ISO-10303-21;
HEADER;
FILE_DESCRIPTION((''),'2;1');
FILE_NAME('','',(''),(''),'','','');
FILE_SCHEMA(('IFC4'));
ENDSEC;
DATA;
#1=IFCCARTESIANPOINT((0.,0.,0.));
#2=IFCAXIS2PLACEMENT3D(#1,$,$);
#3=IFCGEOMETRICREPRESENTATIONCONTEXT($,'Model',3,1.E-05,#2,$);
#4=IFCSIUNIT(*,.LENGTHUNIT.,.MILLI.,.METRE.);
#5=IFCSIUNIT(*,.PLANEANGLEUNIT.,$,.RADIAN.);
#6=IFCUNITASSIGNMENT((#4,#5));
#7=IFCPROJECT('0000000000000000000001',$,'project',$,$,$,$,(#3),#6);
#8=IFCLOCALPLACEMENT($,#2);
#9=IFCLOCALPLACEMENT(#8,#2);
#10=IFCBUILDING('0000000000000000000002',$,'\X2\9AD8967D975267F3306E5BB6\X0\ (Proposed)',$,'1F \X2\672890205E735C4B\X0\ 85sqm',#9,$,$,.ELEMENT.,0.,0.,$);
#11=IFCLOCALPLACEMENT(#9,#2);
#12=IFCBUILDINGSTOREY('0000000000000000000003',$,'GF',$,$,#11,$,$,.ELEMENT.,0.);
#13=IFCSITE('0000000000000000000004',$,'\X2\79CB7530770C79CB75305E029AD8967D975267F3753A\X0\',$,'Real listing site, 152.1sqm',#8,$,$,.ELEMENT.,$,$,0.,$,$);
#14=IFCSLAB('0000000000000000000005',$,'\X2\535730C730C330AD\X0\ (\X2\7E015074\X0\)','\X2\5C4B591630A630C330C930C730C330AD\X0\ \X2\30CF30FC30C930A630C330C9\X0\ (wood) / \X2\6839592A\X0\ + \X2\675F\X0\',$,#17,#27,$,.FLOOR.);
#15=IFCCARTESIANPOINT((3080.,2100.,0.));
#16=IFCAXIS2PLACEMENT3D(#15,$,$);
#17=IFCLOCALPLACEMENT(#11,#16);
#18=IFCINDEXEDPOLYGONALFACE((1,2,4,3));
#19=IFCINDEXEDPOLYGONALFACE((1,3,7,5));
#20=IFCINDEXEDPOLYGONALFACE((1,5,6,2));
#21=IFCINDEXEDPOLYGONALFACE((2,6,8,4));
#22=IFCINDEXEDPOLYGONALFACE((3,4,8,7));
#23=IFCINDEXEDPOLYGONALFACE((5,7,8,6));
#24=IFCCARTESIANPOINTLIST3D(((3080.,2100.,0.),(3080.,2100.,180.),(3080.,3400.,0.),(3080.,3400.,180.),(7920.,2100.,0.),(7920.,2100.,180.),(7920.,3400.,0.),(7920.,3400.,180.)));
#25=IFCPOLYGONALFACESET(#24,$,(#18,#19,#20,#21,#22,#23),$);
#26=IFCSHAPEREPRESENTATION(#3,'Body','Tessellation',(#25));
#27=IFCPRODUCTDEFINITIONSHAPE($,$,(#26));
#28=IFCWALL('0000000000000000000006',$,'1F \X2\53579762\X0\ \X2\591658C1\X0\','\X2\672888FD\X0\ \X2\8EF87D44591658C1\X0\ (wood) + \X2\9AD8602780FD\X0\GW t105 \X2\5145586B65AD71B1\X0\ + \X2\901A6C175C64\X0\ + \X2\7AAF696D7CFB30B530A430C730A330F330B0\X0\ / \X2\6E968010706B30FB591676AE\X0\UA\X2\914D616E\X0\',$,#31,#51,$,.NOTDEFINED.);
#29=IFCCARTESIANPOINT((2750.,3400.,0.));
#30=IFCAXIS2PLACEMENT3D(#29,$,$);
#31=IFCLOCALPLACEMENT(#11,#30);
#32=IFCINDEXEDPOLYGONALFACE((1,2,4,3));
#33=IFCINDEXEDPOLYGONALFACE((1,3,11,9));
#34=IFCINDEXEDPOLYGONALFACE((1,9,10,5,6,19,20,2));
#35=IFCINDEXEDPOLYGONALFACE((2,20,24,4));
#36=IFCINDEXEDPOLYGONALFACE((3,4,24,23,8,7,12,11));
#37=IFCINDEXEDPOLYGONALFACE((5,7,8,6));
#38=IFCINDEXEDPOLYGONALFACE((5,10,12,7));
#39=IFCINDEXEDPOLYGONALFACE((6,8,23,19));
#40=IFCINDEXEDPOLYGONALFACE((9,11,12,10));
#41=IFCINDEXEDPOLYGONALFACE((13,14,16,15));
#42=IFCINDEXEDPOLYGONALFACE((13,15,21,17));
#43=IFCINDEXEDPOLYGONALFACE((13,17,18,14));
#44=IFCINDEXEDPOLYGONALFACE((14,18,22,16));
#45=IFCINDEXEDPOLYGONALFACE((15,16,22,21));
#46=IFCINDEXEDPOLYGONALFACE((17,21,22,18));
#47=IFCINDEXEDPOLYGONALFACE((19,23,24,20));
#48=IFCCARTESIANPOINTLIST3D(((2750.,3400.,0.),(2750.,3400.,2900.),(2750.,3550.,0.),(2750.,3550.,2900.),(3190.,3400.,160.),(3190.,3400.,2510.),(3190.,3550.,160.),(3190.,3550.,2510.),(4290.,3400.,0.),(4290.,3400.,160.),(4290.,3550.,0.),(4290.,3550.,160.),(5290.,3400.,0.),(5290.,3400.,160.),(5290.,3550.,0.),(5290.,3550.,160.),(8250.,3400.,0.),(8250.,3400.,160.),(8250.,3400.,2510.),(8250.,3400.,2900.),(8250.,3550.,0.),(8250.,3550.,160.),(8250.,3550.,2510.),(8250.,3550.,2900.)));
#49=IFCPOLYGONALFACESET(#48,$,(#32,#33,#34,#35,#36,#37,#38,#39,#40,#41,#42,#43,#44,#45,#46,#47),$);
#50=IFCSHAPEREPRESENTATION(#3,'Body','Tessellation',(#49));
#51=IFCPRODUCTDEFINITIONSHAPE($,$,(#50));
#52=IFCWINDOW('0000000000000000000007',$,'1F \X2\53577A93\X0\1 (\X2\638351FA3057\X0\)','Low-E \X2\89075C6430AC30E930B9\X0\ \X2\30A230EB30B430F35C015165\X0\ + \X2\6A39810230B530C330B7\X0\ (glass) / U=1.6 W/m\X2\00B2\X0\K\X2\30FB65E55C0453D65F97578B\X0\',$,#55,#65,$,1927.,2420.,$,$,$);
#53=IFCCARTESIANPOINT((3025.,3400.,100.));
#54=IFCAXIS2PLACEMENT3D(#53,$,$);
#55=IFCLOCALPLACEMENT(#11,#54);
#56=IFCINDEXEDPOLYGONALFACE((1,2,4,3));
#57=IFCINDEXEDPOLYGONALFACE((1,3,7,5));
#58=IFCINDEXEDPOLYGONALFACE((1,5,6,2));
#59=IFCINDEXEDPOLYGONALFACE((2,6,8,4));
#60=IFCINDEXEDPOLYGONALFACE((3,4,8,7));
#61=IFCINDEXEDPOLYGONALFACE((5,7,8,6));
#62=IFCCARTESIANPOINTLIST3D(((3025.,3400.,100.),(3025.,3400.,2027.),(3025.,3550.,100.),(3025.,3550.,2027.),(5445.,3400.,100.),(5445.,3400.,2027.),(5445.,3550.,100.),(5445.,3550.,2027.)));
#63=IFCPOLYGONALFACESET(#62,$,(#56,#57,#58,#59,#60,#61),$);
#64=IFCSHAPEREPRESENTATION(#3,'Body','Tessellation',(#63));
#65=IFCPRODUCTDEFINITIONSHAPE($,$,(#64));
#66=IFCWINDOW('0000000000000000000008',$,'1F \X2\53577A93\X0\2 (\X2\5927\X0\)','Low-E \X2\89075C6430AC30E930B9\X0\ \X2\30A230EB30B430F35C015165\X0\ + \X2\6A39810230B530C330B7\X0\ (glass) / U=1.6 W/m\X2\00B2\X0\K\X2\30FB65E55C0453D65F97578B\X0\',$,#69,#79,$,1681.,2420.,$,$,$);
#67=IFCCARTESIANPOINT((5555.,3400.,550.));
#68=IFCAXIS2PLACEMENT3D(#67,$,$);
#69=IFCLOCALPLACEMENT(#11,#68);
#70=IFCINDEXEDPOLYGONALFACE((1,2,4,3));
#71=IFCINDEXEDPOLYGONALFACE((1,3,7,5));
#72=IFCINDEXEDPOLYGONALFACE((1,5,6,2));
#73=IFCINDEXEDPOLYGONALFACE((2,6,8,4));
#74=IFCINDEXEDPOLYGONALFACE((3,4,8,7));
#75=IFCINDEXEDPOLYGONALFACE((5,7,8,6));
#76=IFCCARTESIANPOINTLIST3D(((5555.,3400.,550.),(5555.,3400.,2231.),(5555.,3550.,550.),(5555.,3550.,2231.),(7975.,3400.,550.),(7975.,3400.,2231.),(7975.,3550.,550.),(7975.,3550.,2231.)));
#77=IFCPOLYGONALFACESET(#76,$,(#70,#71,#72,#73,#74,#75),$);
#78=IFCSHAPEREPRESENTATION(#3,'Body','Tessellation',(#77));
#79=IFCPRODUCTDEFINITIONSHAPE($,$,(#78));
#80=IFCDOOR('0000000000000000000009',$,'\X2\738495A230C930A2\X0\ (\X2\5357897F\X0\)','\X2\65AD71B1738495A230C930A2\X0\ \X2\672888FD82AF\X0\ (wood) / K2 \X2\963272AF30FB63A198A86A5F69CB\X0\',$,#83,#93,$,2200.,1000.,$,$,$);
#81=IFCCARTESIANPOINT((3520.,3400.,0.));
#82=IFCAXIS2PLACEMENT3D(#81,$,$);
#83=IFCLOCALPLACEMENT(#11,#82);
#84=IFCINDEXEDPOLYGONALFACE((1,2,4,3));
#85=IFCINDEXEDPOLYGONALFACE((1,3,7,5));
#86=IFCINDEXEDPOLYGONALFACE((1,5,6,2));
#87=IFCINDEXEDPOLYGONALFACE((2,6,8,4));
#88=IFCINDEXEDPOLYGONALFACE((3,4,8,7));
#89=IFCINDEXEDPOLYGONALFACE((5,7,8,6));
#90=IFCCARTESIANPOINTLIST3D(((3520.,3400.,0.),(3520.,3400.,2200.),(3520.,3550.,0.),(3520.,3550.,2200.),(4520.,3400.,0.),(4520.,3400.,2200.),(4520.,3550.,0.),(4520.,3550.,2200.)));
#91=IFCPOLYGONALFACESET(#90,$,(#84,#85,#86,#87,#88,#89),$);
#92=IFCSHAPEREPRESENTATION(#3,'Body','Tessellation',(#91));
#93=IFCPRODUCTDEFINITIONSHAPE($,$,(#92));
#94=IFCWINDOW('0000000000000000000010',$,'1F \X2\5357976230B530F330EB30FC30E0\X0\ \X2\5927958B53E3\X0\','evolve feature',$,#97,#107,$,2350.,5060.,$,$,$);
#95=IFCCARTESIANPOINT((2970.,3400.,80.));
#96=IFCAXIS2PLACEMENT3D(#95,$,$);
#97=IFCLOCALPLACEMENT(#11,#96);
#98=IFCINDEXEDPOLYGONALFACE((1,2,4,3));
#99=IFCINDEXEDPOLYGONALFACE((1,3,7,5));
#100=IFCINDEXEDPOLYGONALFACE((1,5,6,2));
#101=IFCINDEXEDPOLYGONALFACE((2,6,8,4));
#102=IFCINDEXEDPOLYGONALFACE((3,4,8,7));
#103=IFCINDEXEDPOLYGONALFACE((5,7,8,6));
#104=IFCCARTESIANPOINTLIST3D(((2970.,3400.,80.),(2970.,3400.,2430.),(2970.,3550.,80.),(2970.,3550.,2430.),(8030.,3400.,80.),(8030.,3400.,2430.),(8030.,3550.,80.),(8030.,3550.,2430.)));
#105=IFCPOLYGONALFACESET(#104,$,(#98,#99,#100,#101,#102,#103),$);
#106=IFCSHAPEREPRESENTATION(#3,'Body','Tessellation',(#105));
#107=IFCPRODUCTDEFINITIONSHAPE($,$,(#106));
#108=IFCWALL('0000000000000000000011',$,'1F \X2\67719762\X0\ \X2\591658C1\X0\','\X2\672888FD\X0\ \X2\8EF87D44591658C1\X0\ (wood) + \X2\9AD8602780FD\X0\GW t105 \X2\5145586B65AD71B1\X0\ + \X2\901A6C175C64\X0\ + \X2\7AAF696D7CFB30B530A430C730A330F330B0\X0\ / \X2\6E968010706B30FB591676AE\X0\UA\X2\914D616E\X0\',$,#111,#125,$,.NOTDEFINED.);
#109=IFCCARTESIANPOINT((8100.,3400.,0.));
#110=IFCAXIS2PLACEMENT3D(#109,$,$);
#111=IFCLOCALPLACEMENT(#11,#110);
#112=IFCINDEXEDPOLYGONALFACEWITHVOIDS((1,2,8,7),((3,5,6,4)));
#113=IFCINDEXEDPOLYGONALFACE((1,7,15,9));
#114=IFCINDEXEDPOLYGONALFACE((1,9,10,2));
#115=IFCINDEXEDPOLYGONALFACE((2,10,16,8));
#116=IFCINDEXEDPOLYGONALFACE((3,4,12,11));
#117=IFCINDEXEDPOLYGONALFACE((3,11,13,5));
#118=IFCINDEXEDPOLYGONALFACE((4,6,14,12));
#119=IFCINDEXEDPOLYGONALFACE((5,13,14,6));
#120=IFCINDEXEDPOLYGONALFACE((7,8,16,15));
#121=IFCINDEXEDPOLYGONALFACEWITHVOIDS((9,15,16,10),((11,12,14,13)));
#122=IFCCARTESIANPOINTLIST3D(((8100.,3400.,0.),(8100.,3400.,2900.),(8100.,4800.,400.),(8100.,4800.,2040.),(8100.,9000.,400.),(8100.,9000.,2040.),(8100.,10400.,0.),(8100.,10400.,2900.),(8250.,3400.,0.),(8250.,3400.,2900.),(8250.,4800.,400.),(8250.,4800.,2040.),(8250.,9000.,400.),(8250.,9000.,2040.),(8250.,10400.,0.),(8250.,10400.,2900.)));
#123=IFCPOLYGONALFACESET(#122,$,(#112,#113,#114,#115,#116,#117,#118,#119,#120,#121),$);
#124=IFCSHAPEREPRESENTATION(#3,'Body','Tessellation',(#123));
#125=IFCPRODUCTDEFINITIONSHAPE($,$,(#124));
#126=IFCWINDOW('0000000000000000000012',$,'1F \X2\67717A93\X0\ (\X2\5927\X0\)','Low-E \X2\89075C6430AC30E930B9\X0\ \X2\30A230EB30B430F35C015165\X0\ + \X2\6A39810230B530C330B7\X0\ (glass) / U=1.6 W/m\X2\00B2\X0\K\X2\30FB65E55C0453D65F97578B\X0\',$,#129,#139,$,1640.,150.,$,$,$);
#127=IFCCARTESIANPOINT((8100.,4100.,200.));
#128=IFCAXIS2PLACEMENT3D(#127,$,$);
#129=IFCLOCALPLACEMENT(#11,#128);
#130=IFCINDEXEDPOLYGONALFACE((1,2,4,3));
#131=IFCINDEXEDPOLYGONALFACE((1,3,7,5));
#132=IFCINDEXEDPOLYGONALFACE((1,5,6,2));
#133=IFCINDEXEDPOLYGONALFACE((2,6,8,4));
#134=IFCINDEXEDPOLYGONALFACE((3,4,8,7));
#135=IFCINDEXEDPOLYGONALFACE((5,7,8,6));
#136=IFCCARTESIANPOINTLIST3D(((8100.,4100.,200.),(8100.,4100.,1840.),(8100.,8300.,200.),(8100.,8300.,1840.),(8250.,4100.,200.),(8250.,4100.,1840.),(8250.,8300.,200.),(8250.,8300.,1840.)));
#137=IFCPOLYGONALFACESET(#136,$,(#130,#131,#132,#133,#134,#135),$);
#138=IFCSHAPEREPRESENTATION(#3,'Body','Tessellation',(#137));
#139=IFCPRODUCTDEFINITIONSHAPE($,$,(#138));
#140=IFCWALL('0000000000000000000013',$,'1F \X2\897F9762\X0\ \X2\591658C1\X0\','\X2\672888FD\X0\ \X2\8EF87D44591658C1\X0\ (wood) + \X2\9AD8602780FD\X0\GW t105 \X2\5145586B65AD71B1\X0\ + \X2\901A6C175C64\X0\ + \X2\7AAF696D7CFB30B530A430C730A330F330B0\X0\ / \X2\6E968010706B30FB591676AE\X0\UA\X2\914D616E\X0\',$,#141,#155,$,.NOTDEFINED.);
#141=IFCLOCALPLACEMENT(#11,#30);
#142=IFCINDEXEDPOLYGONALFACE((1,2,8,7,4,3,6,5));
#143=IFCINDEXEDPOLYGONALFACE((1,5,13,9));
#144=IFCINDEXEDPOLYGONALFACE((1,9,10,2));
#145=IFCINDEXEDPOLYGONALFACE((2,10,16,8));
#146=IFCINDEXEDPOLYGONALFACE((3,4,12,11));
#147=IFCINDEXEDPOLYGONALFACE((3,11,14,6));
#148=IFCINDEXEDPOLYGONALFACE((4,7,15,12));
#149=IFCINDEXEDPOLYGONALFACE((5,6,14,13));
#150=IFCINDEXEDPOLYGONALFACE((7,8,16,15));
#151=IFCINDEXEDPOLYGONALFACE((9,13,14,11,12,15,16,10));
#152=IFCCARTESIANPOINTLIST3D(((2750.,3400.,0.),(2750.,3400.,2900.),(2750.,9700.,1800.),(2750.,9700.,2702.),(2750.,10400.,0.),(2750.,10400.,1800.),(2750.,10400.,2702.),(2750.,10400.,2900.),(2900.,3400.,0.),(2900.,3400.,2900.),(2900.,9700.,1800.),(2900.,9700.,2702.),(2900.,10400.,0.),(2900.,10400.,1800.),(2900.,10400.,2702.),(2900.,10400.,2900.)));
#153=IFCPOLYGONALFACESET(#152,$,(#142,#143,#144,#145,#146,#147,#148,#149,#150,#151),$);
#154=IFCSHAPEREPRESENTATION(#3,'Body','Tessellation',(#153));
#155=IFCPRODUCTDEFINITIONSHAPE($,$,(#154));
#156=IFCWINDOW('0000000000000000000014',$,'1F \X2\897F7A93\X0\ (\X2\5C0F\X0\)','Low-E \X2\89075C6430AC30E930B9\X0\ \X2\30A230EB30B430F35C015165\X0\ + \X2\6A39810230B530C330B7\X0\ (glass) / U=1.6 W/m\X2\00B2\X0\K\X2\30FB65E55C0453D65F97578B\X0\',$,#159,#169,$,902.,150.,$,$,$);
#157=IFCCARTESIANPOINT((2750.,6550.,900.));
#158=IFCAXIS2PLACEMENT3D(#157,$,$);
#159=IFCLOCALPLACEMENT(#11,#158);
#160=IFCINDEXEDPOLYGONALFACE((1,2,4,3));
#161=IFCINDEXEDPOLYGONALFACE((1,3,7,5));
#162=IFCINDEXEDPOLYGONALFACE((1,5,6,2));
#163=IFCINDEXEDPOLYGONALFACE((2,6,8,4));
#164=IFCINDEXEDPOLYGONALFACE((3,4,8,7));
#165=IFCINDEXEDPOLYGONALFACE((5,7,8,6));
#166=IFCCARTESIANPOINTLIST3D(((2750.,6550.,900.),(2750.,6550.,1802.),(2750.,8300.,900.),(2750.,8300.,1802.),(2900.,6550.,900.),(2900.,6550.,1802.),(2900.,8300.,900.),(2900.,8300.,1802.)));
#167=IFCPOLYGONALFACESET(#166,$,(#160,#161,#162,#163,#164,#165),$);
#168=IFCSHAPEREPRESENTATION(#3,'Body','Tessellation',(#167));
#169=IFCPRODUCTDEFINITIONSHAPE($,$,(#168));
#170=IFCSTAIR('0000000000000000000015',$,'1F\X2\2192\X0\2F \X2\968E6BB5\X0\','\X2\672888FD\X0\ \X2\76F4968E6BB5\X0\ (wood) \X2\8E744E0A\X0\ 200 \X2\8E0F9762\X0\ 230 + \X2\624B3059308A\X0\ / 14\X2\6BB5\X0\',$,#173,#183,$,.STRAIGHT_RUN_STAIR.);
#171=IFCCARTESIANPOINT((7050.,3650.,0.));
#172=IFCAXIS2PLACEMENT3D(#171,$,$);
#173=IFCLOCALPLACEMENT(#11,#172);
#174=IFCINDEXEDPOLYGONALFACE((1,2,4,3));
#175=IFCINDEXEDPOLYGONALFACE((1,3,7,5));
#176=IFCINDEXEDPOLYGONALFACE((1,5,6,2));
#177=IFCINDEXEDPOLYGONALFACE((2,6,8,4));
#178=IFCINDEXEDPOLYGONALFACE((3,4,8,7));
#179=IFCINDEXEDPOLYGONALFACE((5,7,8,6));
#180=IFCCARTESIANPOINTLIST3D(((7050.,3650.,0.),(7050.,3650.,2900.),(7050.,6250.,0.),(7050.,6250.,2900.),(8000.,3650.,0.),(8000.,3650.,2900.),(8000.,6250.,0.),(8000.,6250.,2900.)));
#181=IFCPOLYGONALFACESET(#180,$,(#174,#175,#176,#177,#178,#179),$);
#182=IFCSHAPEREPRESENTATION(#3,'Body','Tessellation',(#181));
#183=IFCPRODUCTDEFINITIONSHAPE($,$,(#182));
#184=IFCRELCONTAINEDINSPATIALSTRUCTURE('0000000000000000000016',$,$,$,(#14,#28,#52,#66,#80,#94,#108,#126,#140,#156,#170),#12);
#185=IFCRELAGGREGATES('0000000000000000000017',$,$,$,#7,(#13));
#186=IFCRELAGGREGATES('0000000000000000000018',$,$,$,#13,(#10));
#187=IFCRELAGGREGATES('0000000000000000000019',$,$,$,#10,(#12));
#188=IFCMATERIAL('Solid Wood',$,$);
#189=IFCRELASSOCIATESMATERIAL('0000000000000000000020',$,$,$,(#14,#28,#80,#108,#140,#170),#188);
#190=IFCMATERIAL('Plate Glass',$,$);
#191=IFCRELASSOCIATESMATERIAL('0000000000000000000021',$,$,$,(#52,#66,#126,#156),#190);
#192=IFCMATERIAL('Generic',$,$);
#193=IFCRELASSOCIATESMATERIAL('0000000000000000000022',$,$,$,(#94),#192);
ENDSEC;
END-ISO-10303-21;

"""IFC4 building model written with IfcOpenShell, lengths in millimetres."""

from ifc_helpers import new_model, si_unit, frame, frame_2d, origin, place, context, project, spatial, rectangle, extrude, material, element, fill, save


model = new_model("IFC4")

# Units and contexts
model_context = context("Model", 3, precision=1e-05, world=origin())
ifc_project = project(units=[si_unit("LENGTHUNIT", "METRE", prefix="MILLI"), si_unit("PLANEANGLEUNIT", "RADIAN")], contexts=[model_context])

# Site, building, storey
site_placement = place(None, origin())
site = spatial("IfcSite", under=ifc_project, at=site_placement, Name="秋田県秋田市高陽青柳町", ObjectType="Real listing site, 152.1sqm", CompositionType="ELEMENT", RefElevation=0.0)
building_placement = place(site_placement, origin())
building = spatial("IfcBuilding", under=site, at=building_placement, Name="高陽青柳の家 (Proposed)", ObjectType="1F 木造平屋 85sqm", CompositionType="ELEMENT", ElevationOfRefHeight=0.0, ElevationOfTerrain=0.0)
storey_placement = place(building_placement, origin())
storey = spatial("IfcBuildingStorey", under=building, at=storey_placement, Name="GF", CompositionType="ELEMENT", Elevation=0.0)

# Slab
ifc_material_1 = material(Name="Solid Wood")
slab_1_placement = place(storey_placement, frame((3080.0, 2100.0, 0.0)))
element("IfcSlab", 1, at=slab_1_placement, inside=storey, material=ifc_material_1, Name="南デッキ (縁側)", Description="屋外ウッドデッキ ハードウッド (wood) / 根太 + 束", PredefinedType="FLOOR", context=model_context, shape_type="SweptSolid", body=[
    extrude(rectangle(XDim=4840.0, YDim=1300.0, at=frame_2d((2420.0, 650.0))), frame((3080.0, 2100.0, 0.0)), (0.0, 0.0, 1.0), 180.0),
])
ifc_material_2 = material(Name="Generic")

# Wall, openings, windows, door
wall_1_placement = place(storey_placement, frame((2750.0, 3400.0, 0.0)))
wall_1 = element("IfcWall", 2, at=wall_1_placement, inside=storey, material=ifc_material_1, Name="1F 南面 外壁", Description="木製 軸組外壁 (wood) + 高性能GW t105 充填断熱 + 通気層 + 窯業系サイディング / 準耐火・外皮UA配慮", PredefinedType="NOTDEFINED", context=model_context, shape_type="SweptSolid", body=[
    extrude(rectangle(XDim=5500.0, YDim=150.0, at=frame_2d((2750.0, 75.0))), frame((2750.0, 3400.0, 0.0)), (0.0, 0.0, 1.0), 2900.0),
])
opening_1_placement = place(storey_placement, frame((3025.0, 3400.0, 100.0)))
opening_1 = element("IfcOpeningElement", 3, at=opening_1_placement, cuts=wall_1, PredefinedType="NOTDEFINED", context=model_context, shape_type="SweptSolid", body=[
    extrude(rectangle(XDim=2420.0, YDim=150.0, at=frame_2d((1210.0, 75.0))), frame((3025.0, 3400.0, 100.0)), (0.0, 0.0, 1.0), 1927.0),
])
opening_2_placement = place(storey_placement, frame((5555.0, 3400.0, 550.0)))
opening_2 = element("IfcOpeningElement", 4, at=opening_2_placement, cuts=wall_1, PredefinedType="NOTDEFINED", context=model_context, shape_type="SweptSolid", body=[
    extrude(rectangle(XDim=2420.0, YDim=150.0, at=frame_2d((1210.0, 75.0))), frame((5555.0, 3400.0, 550.0)), (0.0, 0.0, 1.0), 1681.0),
])
opening_3_placement = place(storey_placement, frame((3520.0, 3400.0, 0.0)))
opening_3 = element("IfcOpeningElement", 5, at=opening_3_placement, cuts=wall_1, PredefinedType="NOTDEFINED", context=model_context, shape_type="SweptSolid", body=[
    extrude(rectangle(XDim=1000.0, YDim=150.0, at=frame_2d((500.0, 75.0))), frame((3520.0, 3400.0, 0.0)), (0.0, 0.0, 1.0), 2200.0),
])
opening_4_placement = place(storey_placement, frame((2970.0, 3400.0, 80.0)))
opening_4 = element("IfcOpeningElement", 6, at=opening_4_placement, cuts=wall_1, PredefinedType="NOTDEFINED", context=model_context, shape_type="SweptSolid", body=[
    extrude(rectangle(XDim=5060.0, YDim=150.0, at=frame_2d((2530.0, 75.0))), frame((2970.0, 3400.0, 80.0)), (0.0, 0.0, 1.0), 2350.0),
])
ifc_material_3 = material(Name="Plate Glass")
window_1_placement = place(storey_placement, frame((3025.0, 3400.0, 100.0)))
window_1 = element("IfcWindow", 7, at=window_1_placement, inside=storey, material=ifc_material_3, Name="1F 南窓1 (掃出し)", Description="Low-E 複層ガラス アルゴン封入 + 樹脂サッシ (glass) / U=1.6 W/m²K・日射取得型", OverallHeight=1927.0, OverallWidth=2420.0, context=model_context, shape_type="SweptSolid", body=[
    extrude(rectangle(XDim=2420.0, YDim=150.0, at=frame_2d((1210.0, 75.0))), frame((3025.0, 3400.0, 100.0)), (0.0, 0.0, 1.0), 1927.0),
])
fill(opening_1, window_1)
window_2_placement = place(storey_placement, frame((5555.0, 3400.0, 550.0)))
window_2 = element("IfcWindow", 8, at=window_2_placement, inside=storey, material=ifc_material_3, Name="1F 南窓2 (大)", Description="Low-E 複層ガラス アルゴン封入 + 樹脂サッシ (glass) / U=1.6 W/m²K・日射取得型", OverallHeight=1681.0, OverallWidth=2420.0, context=model_context, shape_type="SweptSolid", body=[
    extrude(rectangle(XDim=2420.0, YDim=150.0, at=frame_2d((1210.0, 75.0))), frame((5555.0, 3400.0, 550.0)), (0.0, 0.0, 1.0), 1681.0),
])
fill(opening_2, window_2)
door_placement = place(storey_placement, frame((3520.0, 3400.0, 0.0)))
door = element("IfcDoor", 9, at=door_placement, inside=storey, material=ifc_material_1, Name="玄関ドア (南西)", Description="断熱玄関ドア 木製芯 (wood) / K2 防犯・採風機構", OverallHeight=2200.0, OverallWidth=1000.0, context=model_context, shape_type="SweptSolid", body=[
    extrude(rectangle(XDim=1000.0, YDim=150.0, at=frame_2d((500.0, 75.0))), frame((3520.0, 3400.0, 0.0)), (0.0, 0.0, 1.0), 2200.0),
])
fill(opening_3, door)
window_3_placement = place(storey_placement, frame((2970.0, 3400.0, 80.0)))
window_3 = element("IfcWindow", 10, at=window_3_placement, inside=storey, material=ifc_material_2, Name="1F 南面サンルーム 大開口", Description="evolve feature", OverallHeight=2350.0, OverallWidth=5060.0, context=model_context, shape_type="SweptSolid", body=[
    extrude(rectangle(XDim=5060.0, YDim=150.0, at=frame_2d((2530.0, 75.0))), frame((2970.0, 3400.0, 80.0)), (0.0, 0.0, 1.0), 2350.0),
])
fill(opening_4, window_3)

# Walls, openings, windows
wall_2_placement = place(storey_placement, frame((8100.0, 3400.0, 0.0)))
wall_2 = element("IfcWall", 11, at=wall_2_placement, inside=storey, material=ifc_material_1, Name="1F 東面 外壁", Description="木製 軸組外壁 (wood) + 高性能GW t105 充填断熱 + 通気層 + 窯業系サイディング / 準耐火・外皮UA配慮", PredefinedType="NOTDEFINED", context=model_context, shape_type="SweptSolid", body=[
    extrude(rectangle(XDim=150.0, YDim=7000.0, at=frame_2d((75.0, 3500.0))), frame((8100.0, 3400.0, 0.0)), (0.0, 0.0, 1.0), 2900.0),
])
opening_5_placement = place(storey_placement, frame((8100.0, 4100.0, 200.0)))
opening_5 = element("IfcOpeningElement", 12, at=opening_5_placement, cuts=wall_2, PredefinedType="NOTDEFINED", context=model_context, shape_type="SweptSolid", body=[
    extrude(rectangle(XDim=150.0, YDim=4200.0, at=frame_2d((75.0, 2100.0))), frame((8100.0, 4100.0, 200.0)), (0.0, 0.0, 1.0), 1640.0),
])
window_4_placement = place(storey_placement, frame((8100.0, 4100.0, 200.0)))
window_4 = element("IfcWindow", 13, at=window_4_placement, inside=storey, material=ifc_material_3, Name="1F 東窓 (大)", Description="Low-E 複層ガラス アルゴン封入 + 樹脂サッシ (glass) / U=1.6 W/m²K・日射取得型", OverallHeight=1640.0, OverallWidth=150.0, context=model_context, shape_type="SweptSolid", body=[
    extrude(rectangle(XDim=150.0, YDim=4200.0, at=frame_2d((75.0, 2100.0))), frame((8100.0, 4100.0, 200.0)), (0.0, 0.0, 1.0), 1640.0),
])
fill(opening_5, window_4)
wall_3_placement = place(storey_placement, frame((2750.0, 3400.0, 0.0)))
wall_3 = element("IfcWall", 14, at=wall_3_placement, inside=storey, material=ifc_material_1, Name="1F 西面 外壁", Description="木製 軸組外壁 (wood) + 高性能GW t105 充填断熱 + 通気層 + 窯業系サイディング / 準耐火・外皮UA配慮", PredefinedType="NOTDEFINED", context=model_context, shape_type="SweptSolid", body=[
    extrude(rectangle(XDim=150.0, YDim=7000.0, at=frame_2d((75.0, 3500.0))), frame((2750.0, 3400.0, 0.0)), (0.0, 0.0, 1.0), 2900.0),
])
opening_6_placement = place(storey_placement, frame((2750.0, 6550.0, 900.0)))
opening_6 = element("IfcOpeningElement", 15, at=opening_6_placement, cuts=wall_3, PredefinedType="NOTDEFINED", context=model_context, shape_type="SweptSolid", body=[
    extrude(rectangle(XDim=150.0, YDim=1750.0, at=frame_2d((75.0, 875.0))), frame((2750.0, 6550.0, 900.0)), (0.0, 0.0, 1.0), 902.0),
])
window_5_placement = place(storey_placement, frame((2750.0, 6550.0, 900.0)))
window_5 = element("IfcWindow", 16, at=window_5_placement, inside=storey, material=ifc_material_3, Name="1F 西窓 (小)", Description="Low-E 複層ガラス アルゴン封入 + 樹脂サッシ (glass) / U=1.6 W/m²K・日射取得型", OverallHeight=902.0, OverallWidth=150.0, context=model_context, shape_type="SweptSolid", body=[
    extrude(rectangle(XDim=150.0, YDim=1750.0, at=frame_2d((75.0, 875.0))), frame((2750.0, 6550.0, 900.0)), (0.0, 0.0, 1.0), 902.0),
])
fill(opening_6, window_5)

# Stair
stair_placement = place(storey_placement, frame((7050.0, 3650.0, 0.0)))
element("IfcStair", 17, at=stair_placement, inside=storey, material=ifc_material_1, Name="1F→2F 階段", Description="木製 直階段 (wood) 蹴上 200 踏面 230 + 手すり / 14段", PredefinedType="STRAIGHT_RUN_STAIR", context=model_context, shape_type="SweptSolid", body=[
    extrude(rectangle(XDim=950.0, YDim=2600.0, at=frame_2d((475.0, 1300.0))), frame((7050.0, 3650.0, 0.0)), (0.0, 0.0, 1.0), 2900.0),
])

save(model, "model.ifc")
